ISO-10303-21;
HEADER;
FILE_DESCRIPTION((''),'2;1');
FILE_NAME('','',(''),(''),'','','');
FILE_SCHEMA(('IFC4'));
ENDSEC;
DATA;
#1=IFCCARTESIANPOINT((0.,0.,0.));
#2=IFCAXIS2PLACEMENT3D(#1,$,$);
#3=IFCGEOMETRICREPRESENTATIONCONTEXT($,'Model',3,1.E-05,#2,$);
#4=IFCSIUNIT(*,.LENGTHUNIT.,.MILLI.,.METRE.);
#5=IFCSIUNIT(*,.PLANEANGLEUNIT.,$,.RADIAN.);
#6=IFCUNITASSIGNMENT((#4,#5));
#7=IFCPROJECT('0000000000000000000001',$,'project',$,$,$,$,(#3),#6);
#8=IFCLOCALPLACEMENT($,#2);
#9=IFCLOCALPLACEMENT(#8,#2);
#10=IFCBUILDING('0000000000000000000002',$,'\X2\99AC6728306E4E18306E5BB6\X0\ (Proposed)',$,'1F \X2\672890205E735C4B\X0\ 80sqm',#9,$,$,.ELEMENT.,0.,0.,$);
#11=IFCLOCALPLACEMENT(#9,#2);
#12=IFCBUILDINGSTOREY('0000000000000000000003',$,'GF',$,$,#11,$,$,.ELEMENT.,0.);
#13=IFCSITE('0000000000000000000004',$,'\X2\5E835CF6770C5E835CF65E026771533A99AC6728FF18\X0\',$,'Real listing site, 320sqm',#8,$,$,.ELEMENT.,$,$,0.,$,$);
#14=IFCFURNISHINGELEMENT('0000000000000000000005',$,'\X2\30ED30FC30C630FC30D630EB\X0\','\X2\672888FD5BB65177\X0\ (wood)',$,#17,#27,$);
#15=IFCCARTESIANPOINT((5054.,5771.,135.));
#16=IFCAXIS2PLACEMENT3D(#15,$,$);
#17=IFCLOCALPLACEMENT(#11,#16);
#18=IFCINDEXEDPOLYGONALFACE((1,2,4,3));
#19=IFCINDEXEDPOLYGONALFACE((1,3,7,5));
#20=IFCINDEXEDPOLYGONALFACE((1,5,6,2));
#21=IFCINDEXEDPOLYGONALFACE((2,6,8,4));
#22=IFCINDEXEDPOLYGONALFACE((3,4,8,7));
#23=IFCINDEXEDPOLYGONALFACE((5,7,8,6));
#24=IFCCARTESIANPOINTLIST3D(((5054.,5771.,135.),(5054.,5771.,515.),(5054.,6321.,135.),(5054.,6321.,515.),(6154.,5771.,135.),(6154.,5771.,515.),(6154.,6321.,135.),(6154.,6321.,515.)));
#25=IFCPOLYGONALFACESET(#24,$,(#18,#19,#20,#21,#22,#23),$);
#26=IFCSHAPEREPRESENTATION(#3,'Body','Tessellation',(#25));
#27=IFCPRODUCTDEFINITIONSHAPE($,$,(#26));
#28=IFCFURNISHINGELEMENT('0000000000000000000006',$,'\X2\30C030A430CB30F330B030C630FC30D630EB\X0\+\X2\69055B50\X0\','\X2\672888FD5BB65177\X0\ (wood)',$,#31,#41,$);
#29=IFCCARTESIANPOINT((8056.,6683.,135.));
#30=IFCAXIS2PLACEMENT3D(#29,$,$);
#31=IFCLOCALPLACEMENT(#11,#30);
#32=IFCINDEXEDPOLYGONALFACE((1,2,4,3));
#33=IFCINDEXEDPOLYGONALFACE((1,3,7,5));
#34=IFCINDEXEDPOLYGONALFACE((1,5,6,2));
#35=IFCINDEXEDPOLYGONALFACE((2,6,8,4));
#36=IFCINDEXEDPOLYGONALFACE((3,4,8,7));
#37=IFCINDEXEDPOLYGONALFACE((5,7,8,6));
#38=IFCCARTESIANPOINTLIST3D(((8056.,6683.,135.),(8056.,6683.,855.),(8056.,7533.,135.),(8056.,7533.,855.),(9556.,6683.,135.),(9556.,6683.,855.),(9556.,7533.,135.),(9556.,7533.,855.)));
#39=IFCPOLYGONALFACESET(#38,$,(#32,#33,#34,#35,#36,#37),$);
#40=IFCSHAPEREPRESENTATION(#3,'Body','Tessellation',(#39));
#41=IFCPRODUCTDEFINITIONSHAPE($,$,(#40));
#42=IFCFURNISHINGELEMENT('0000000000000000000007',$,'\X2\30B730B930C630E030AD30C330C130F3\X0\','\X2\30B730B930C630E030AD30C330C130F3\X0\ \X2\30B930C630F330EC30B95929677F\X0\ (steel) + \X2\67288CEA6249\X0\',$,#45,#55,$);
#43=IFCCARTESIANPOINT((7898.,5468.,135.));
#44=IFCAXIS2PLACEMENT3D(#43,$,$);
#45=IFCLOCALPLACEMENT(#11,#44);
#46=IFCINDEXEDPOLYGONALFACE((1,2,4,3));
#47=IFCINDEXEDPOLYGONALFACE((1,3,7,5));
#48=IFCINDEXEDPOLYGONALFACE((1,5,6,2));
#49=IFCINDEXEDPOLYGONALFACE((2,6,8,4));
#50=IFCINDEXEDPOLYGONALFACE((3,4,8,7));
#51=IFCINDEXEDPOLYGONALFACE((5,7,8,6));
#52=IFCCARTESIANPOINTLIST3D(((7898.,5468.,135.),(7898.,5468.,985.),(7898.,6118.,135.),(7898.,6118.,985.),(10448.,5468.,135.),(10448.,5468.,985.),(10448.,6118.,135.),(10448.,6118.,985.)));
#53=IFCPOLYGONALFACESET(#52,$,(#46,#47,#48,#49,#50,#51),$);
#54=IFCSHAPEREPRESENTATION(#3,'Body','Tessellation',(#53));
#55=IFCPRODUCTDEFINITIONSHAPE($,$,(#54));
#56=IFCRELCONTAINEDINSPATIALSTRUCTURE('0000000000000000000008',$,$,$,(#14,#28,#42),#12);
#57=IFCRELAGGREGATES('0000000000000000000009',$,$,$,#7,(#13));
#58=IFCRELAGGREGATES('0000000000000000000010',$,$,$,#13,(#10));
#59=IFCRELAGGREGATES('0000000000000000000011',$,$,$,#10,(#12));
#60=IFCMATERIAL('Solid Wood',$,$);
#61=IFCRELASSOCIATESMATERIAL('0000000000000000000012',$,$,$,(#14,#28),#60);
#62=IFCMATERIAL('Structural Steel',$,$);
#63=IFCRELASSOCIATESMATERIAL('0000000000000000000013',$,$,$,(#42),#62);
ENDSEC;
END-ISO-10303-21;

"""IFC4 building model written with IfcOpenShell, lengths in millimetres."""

from ifc_helpers import new_model, si_unit, frame, frame_2d, origin, place, context, project, spatial, rectangle, extrude, material, element, save


model = new_model("IFC4")

# Units and contexts
model_context = context("Model", 3, precision=1e-05, world=origin())
ifc_project = project(units=[si_unit("LENGTHUNIT", "METRE", prefix="MILLI"), si_unit("PLANEANGLEUNIT", "RADIAN")], contexts=[model_context])

# Site, building, storey
site_placement = place(None, origin())
site = spatial("IfcSite", under=ifc_project, at=site_placement, Name="広島県広島市東区馬木８", ObjectType="Real listing site, 320sqm", CompositionType="ELEMENT", RefElevation=0.0)
building_placement = place(site_placement, origin())
building = spatial("IfcBuilding", under=site, at=building_placement, Name="馬木の丘の家 (Proposed)", ObjectType="1F 木造平屋 80sqm", CompositionType="ELEMENT", ElevationOfRefHeight=0.0, ElevationOfTerrain=0.0)
storey_placement = place(building_placement, origin())
storey = spatial("IfcBuildingStorey", under=building, at=storey_placement, Name="GF", CompositionType="ELEMENT", Elevation=0.0)

# Shared definitions
ifc_material_1 = material(Name="Solid Wood")

# Shared definitions
ifc_material_2 = material(Name="Structural Steel")

# Furnishing elements
furnishing_1_placement = place(storey_placement, frame((5054.0, 5771.0, 135.0)))
element("IfcFurnishingElement", 1, at=furnishing_1_placement, inside=storey, material=ifc_material_1, Name="ローテーブル", Description="木製家具 (wood)", context=model_context, shape_type="SweptSolid", body=[
    extrude(rectangle(XDim=1100.0, YDim=550.0, at=frame_2d((550.0, 275.0))), frame((5054.0, 5771.0, 135.0)), (0.0, 0.0, 1.0), 380.0),
])
furnishing_2_placement = place(storey_placement, frame((8056.0, 6683.0, 135.0)))
element("IfcFurnishingElement", 2, at=furnishing_2_placement, inside=storey, material=ifc_material_1, Name="ダイニングテーブル+椅子", Description="木製家具 (wood)", context=model_context, shape_type="SweptSolid", body=[
    extrude(rectangle(XDim=1500.0, YDim=850.0, at=frame_2d((750.0, 425.0))), frame((8056.0, 6683.0, 135.0)), (0.0, 0.0, 1.0), 720.0),
])
furnishing_3_placement = place(storey_placement, frame((7898.0, 5468.0, 135.0)))
element("IfcFurnishingElement", 3, at=furnishing_3_placement, inside=storey, material=ifc_material_2, Name="システムキッチン", Description="システムキッチン ステンレス天板 (steel) + 木質扉", context=model_context, shape_type="SweptSolid", body=[
    extrude(rectangle(XDim=2550.0, YDim=650.0, at=frame_2d((1275.0, 325.0))), frame((7898.0, 5468.0, 135.0)), (0.0, 0.0, 1.0), 850.0),
])

save(model, "model.ifc")
